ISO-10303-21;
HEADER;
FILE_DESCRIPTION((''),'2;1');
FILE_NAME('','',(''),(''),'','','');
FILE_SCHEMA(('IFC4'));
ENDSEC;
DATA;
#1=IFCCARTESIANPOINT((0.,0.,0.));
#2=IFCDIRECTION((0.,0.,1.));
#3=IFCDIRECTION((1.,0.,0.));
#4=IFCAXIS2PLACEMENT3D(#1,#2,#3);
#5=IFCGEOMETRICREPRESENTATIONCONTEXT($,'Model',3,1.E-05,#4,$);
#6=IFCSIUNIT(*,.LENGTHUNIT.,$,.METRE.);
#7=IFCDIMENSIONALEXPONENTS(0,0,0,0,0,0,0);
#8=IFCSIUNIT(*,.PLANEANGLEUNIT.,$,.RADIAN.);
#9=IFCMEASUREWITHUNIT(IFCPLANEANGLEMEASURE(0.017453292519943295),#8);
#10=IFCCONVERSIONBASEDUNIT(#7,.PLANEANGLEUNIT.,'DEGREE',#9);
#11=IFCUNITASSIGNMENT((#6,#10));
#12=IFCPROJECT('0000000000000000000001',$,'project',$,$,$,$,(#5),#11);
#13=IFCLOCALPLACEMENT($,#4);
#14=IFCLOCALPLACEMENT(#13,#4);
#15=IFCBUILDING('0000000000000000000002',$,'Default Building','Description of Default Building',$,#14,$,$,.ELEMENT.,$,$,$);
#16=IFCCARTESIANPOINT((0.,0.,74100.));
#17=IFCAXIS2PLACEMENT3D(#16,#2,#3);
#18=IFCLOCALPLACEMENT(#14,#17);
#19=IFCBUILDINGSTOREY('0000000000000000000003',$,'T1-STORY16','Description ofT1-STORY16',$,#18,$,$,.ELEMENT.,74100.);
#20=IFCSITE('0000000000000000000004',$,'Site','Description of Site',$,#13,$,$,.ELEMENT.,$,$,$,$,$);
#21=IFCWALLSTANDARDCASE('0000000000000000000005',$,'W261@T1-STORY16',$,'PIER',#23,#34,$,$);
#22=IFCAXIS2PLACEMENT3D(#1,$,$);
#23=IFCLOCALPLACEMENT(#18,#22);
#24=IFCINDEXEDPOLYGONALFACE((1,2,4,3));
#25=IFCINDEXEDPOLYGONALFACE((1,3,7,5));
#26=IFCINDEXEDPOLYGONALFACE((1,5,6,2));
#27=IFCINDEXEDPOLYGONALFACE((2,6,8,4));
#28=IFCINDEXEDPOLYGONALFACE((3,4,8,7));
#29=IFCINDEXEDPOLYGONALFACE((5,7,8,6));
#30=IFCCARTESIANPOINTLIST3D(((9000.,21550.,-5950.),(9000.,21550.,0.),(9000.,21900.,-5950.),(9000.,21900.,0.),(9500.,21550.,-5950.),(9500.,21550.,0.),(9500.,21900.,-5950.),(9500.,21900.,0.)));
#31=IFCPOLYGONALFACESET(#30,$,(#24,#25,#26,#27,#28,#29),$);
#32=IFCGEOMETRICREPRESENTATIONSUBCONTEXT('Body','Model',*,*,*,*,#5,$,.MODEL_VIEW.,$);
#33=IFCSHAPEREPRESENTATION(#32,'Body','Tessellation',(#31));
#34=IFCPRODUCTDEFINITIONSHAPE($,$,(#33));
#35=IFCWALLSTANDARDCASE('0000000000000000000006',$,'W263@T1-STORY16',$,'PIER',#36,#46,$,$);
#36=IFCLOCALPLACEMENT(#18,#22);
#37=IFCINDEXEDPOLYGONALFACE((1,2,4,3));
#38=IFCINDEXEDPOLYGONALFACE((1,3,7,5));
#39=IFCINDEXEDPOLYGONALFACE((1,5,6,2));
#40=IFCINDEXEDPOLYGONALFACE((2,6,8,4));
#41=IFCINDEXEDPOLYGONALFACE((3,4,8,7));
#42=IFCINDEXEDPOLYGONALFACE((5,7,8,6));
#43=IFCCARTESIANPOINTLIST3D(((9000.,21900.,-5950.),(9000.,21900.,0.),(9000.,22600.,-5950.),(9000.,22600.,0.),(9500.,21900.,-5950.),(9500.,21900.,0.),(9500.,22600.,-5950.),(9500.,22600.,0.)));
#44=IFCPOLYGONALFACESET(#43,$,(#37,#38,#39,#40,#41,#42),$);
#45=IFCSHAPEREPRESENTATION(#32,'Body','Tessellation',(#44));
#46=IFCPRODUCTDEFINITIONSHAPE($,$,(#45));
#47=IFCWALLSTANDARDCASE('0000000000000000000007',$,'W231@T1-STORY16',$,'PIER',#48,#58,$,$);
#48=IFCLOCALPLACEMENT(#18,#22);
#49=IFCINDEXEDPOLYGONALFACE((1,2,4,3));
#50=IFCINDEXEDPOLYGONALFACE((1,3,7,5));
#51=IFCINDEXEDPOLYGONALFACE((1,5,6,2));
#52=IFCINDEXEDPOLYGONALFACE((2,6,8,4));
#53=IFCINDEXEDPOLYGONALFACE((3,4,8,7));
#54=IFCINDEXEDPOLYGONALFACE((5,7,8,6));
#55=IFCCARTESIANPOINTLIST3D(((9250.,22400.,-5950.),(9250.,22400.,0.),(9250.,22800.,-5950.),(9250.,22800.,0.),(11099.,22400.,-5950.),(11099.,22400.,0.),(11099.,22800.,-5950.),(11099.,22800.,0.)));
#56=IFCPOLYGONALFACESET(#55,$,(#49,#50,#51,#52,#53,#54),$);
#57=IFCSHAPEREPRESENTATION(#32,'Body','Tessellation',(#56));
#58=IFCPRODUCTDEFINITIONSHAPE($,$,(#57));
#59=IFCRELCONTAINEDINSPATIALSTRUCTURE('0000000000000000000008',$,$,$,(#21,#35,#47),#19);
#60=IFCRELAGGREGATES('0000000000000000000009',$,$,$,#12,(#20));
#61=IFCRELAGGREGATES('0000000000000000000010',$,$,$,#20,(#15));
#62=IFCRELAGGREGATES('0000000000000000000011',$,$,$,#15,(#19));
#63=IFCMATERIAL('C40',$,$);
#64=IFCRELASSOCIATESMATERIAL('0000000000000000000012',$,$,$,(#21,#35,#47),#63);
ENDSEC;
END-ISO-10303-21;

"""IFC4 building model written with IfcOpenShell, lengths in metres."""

from ifc_helpers import new_model, entity, si_unit, converted_unit, frame, origin_with_axes, place, context, subcontext, project, spatial, indexed_curve, outline, extrude, material, element, save


model = new_model("IFC4")

# Units and contexts
model_context = context("Model", 3, precision=1e-05, world=origin_with_axes())
body_context = subcontext(model_context, "Body", "Model", "MODEL_VIEW")
ifc_project = project(units=[si_unit("LENGTHUNIT", "METRE"), converted_unit("PLANEANGLEUNIT", "DEGREE", entity("IfcPlaneAngleMeasure", 0.017453292519943295), si_unit("PLANEANGLEUNIT", "RADIAN"), dimensions=[0, 0, 0, 0, 0, 0, 0])], contexts=[model_context])

# Site, building, storey
site_placement = place(None, origin_with_axes())
site = spatial("IfcSite", under=ifc_project, at=site_placement, Name="Site", Description="Description of Site", CompositionType="ELEMENT")
building_placement = place(site_placement, origin_with_axes())
building = spatial("IfcBuilding", under=site, at=building_placement, Name="Default Building", Description="Description of Default Building", CompositionType="ELEMENT")
storey_placement = place(building_placement, frame((0.0, 0.0, 74100.0), z_axis=(0.0, 0.0, 1.0), x_axis=(1.0, 0.0, 0.0)))
storey = spatial("IfcBuildingStorey", under=building, at=storey_placement, Name="T1-STORY16", Description="Description ofT1-STORY16", CompositionType="ELEMENT", Elevation=74100.0)

# Shared definitions
ifc_material_1 = material(Name="C40")

# Walls
wall_1_placement = place(storey_placement, frame((9250.0, 21550.0, -5950.0), z_axis=(0.0, 0.0, 1.0), x_axis=(0.0, 1.0, 0.0)))
element("IfcWallStandardCase", 1, at=wall_1_placement, inside=storey, material=ifc_material_1, Name="W261@T1-STORY16", ObjectType="PIER", context=body_context, shape_type="SweptSolid", body=[
    extrude(outline(indexed_curve([(0.0, -250.0), (0.0, 250.0), (350.0, 250.0), (350.0, -250.0), (0.0, -250.0)], self_intersect=False)), origin_with_axes(), (0.0, 0.0, 1.0), 5950.0),
])
wall_2_placement = place(storey_placement, frame((9250.0, 21900.0, -5950.0), z_axis=(0.0, 0.0, 1.0), x_axis=(0.0, 1.0, 0.0)))
element("IfcWallStandardCase", 2, at=wall_2_placement, inside=storey, material=ifc_material_1, Name="W263@T1-STORY16", ObjectType="PIER", context=body_context, shape_type="SweptSolid", body=[
    extrude(outline(indexed_curve([(0.0, -250.0), (0.0, 250.0), (700.0, 250.0), (700.0, -250.0), (0.0, -250.0)], self_intersect=False)), origin_with_axes(), (0.0, 0.0, 1.0), 5950.0),
])
wall_3_placement = place(storey_placement, frame((9250.0, 22600.0, -5950.0), z_axis=(0.0, 0.0, 1.0), x_axis=(1.0, 0.0, 0.0)))
element("IfcWallStandardCase", 3, at=wall_3_placement, inside=storey, material=ifc_material_1, Name="W231@T1-STORY16", ObjectType="PIER", context=body_context, shape_type="SweptSolid", body=[
    extrude(outline(indexed_curve([(0.0, -200.0), (0.0, 200.0), (1849.0, 200.0), (1849.0, -200.0), (0.0, -200.0)], self_intersect=False)), origin_with_axes(), (0.0, 0.0, 1.0), 5950.0),
])

save(model, "model.ifc")
